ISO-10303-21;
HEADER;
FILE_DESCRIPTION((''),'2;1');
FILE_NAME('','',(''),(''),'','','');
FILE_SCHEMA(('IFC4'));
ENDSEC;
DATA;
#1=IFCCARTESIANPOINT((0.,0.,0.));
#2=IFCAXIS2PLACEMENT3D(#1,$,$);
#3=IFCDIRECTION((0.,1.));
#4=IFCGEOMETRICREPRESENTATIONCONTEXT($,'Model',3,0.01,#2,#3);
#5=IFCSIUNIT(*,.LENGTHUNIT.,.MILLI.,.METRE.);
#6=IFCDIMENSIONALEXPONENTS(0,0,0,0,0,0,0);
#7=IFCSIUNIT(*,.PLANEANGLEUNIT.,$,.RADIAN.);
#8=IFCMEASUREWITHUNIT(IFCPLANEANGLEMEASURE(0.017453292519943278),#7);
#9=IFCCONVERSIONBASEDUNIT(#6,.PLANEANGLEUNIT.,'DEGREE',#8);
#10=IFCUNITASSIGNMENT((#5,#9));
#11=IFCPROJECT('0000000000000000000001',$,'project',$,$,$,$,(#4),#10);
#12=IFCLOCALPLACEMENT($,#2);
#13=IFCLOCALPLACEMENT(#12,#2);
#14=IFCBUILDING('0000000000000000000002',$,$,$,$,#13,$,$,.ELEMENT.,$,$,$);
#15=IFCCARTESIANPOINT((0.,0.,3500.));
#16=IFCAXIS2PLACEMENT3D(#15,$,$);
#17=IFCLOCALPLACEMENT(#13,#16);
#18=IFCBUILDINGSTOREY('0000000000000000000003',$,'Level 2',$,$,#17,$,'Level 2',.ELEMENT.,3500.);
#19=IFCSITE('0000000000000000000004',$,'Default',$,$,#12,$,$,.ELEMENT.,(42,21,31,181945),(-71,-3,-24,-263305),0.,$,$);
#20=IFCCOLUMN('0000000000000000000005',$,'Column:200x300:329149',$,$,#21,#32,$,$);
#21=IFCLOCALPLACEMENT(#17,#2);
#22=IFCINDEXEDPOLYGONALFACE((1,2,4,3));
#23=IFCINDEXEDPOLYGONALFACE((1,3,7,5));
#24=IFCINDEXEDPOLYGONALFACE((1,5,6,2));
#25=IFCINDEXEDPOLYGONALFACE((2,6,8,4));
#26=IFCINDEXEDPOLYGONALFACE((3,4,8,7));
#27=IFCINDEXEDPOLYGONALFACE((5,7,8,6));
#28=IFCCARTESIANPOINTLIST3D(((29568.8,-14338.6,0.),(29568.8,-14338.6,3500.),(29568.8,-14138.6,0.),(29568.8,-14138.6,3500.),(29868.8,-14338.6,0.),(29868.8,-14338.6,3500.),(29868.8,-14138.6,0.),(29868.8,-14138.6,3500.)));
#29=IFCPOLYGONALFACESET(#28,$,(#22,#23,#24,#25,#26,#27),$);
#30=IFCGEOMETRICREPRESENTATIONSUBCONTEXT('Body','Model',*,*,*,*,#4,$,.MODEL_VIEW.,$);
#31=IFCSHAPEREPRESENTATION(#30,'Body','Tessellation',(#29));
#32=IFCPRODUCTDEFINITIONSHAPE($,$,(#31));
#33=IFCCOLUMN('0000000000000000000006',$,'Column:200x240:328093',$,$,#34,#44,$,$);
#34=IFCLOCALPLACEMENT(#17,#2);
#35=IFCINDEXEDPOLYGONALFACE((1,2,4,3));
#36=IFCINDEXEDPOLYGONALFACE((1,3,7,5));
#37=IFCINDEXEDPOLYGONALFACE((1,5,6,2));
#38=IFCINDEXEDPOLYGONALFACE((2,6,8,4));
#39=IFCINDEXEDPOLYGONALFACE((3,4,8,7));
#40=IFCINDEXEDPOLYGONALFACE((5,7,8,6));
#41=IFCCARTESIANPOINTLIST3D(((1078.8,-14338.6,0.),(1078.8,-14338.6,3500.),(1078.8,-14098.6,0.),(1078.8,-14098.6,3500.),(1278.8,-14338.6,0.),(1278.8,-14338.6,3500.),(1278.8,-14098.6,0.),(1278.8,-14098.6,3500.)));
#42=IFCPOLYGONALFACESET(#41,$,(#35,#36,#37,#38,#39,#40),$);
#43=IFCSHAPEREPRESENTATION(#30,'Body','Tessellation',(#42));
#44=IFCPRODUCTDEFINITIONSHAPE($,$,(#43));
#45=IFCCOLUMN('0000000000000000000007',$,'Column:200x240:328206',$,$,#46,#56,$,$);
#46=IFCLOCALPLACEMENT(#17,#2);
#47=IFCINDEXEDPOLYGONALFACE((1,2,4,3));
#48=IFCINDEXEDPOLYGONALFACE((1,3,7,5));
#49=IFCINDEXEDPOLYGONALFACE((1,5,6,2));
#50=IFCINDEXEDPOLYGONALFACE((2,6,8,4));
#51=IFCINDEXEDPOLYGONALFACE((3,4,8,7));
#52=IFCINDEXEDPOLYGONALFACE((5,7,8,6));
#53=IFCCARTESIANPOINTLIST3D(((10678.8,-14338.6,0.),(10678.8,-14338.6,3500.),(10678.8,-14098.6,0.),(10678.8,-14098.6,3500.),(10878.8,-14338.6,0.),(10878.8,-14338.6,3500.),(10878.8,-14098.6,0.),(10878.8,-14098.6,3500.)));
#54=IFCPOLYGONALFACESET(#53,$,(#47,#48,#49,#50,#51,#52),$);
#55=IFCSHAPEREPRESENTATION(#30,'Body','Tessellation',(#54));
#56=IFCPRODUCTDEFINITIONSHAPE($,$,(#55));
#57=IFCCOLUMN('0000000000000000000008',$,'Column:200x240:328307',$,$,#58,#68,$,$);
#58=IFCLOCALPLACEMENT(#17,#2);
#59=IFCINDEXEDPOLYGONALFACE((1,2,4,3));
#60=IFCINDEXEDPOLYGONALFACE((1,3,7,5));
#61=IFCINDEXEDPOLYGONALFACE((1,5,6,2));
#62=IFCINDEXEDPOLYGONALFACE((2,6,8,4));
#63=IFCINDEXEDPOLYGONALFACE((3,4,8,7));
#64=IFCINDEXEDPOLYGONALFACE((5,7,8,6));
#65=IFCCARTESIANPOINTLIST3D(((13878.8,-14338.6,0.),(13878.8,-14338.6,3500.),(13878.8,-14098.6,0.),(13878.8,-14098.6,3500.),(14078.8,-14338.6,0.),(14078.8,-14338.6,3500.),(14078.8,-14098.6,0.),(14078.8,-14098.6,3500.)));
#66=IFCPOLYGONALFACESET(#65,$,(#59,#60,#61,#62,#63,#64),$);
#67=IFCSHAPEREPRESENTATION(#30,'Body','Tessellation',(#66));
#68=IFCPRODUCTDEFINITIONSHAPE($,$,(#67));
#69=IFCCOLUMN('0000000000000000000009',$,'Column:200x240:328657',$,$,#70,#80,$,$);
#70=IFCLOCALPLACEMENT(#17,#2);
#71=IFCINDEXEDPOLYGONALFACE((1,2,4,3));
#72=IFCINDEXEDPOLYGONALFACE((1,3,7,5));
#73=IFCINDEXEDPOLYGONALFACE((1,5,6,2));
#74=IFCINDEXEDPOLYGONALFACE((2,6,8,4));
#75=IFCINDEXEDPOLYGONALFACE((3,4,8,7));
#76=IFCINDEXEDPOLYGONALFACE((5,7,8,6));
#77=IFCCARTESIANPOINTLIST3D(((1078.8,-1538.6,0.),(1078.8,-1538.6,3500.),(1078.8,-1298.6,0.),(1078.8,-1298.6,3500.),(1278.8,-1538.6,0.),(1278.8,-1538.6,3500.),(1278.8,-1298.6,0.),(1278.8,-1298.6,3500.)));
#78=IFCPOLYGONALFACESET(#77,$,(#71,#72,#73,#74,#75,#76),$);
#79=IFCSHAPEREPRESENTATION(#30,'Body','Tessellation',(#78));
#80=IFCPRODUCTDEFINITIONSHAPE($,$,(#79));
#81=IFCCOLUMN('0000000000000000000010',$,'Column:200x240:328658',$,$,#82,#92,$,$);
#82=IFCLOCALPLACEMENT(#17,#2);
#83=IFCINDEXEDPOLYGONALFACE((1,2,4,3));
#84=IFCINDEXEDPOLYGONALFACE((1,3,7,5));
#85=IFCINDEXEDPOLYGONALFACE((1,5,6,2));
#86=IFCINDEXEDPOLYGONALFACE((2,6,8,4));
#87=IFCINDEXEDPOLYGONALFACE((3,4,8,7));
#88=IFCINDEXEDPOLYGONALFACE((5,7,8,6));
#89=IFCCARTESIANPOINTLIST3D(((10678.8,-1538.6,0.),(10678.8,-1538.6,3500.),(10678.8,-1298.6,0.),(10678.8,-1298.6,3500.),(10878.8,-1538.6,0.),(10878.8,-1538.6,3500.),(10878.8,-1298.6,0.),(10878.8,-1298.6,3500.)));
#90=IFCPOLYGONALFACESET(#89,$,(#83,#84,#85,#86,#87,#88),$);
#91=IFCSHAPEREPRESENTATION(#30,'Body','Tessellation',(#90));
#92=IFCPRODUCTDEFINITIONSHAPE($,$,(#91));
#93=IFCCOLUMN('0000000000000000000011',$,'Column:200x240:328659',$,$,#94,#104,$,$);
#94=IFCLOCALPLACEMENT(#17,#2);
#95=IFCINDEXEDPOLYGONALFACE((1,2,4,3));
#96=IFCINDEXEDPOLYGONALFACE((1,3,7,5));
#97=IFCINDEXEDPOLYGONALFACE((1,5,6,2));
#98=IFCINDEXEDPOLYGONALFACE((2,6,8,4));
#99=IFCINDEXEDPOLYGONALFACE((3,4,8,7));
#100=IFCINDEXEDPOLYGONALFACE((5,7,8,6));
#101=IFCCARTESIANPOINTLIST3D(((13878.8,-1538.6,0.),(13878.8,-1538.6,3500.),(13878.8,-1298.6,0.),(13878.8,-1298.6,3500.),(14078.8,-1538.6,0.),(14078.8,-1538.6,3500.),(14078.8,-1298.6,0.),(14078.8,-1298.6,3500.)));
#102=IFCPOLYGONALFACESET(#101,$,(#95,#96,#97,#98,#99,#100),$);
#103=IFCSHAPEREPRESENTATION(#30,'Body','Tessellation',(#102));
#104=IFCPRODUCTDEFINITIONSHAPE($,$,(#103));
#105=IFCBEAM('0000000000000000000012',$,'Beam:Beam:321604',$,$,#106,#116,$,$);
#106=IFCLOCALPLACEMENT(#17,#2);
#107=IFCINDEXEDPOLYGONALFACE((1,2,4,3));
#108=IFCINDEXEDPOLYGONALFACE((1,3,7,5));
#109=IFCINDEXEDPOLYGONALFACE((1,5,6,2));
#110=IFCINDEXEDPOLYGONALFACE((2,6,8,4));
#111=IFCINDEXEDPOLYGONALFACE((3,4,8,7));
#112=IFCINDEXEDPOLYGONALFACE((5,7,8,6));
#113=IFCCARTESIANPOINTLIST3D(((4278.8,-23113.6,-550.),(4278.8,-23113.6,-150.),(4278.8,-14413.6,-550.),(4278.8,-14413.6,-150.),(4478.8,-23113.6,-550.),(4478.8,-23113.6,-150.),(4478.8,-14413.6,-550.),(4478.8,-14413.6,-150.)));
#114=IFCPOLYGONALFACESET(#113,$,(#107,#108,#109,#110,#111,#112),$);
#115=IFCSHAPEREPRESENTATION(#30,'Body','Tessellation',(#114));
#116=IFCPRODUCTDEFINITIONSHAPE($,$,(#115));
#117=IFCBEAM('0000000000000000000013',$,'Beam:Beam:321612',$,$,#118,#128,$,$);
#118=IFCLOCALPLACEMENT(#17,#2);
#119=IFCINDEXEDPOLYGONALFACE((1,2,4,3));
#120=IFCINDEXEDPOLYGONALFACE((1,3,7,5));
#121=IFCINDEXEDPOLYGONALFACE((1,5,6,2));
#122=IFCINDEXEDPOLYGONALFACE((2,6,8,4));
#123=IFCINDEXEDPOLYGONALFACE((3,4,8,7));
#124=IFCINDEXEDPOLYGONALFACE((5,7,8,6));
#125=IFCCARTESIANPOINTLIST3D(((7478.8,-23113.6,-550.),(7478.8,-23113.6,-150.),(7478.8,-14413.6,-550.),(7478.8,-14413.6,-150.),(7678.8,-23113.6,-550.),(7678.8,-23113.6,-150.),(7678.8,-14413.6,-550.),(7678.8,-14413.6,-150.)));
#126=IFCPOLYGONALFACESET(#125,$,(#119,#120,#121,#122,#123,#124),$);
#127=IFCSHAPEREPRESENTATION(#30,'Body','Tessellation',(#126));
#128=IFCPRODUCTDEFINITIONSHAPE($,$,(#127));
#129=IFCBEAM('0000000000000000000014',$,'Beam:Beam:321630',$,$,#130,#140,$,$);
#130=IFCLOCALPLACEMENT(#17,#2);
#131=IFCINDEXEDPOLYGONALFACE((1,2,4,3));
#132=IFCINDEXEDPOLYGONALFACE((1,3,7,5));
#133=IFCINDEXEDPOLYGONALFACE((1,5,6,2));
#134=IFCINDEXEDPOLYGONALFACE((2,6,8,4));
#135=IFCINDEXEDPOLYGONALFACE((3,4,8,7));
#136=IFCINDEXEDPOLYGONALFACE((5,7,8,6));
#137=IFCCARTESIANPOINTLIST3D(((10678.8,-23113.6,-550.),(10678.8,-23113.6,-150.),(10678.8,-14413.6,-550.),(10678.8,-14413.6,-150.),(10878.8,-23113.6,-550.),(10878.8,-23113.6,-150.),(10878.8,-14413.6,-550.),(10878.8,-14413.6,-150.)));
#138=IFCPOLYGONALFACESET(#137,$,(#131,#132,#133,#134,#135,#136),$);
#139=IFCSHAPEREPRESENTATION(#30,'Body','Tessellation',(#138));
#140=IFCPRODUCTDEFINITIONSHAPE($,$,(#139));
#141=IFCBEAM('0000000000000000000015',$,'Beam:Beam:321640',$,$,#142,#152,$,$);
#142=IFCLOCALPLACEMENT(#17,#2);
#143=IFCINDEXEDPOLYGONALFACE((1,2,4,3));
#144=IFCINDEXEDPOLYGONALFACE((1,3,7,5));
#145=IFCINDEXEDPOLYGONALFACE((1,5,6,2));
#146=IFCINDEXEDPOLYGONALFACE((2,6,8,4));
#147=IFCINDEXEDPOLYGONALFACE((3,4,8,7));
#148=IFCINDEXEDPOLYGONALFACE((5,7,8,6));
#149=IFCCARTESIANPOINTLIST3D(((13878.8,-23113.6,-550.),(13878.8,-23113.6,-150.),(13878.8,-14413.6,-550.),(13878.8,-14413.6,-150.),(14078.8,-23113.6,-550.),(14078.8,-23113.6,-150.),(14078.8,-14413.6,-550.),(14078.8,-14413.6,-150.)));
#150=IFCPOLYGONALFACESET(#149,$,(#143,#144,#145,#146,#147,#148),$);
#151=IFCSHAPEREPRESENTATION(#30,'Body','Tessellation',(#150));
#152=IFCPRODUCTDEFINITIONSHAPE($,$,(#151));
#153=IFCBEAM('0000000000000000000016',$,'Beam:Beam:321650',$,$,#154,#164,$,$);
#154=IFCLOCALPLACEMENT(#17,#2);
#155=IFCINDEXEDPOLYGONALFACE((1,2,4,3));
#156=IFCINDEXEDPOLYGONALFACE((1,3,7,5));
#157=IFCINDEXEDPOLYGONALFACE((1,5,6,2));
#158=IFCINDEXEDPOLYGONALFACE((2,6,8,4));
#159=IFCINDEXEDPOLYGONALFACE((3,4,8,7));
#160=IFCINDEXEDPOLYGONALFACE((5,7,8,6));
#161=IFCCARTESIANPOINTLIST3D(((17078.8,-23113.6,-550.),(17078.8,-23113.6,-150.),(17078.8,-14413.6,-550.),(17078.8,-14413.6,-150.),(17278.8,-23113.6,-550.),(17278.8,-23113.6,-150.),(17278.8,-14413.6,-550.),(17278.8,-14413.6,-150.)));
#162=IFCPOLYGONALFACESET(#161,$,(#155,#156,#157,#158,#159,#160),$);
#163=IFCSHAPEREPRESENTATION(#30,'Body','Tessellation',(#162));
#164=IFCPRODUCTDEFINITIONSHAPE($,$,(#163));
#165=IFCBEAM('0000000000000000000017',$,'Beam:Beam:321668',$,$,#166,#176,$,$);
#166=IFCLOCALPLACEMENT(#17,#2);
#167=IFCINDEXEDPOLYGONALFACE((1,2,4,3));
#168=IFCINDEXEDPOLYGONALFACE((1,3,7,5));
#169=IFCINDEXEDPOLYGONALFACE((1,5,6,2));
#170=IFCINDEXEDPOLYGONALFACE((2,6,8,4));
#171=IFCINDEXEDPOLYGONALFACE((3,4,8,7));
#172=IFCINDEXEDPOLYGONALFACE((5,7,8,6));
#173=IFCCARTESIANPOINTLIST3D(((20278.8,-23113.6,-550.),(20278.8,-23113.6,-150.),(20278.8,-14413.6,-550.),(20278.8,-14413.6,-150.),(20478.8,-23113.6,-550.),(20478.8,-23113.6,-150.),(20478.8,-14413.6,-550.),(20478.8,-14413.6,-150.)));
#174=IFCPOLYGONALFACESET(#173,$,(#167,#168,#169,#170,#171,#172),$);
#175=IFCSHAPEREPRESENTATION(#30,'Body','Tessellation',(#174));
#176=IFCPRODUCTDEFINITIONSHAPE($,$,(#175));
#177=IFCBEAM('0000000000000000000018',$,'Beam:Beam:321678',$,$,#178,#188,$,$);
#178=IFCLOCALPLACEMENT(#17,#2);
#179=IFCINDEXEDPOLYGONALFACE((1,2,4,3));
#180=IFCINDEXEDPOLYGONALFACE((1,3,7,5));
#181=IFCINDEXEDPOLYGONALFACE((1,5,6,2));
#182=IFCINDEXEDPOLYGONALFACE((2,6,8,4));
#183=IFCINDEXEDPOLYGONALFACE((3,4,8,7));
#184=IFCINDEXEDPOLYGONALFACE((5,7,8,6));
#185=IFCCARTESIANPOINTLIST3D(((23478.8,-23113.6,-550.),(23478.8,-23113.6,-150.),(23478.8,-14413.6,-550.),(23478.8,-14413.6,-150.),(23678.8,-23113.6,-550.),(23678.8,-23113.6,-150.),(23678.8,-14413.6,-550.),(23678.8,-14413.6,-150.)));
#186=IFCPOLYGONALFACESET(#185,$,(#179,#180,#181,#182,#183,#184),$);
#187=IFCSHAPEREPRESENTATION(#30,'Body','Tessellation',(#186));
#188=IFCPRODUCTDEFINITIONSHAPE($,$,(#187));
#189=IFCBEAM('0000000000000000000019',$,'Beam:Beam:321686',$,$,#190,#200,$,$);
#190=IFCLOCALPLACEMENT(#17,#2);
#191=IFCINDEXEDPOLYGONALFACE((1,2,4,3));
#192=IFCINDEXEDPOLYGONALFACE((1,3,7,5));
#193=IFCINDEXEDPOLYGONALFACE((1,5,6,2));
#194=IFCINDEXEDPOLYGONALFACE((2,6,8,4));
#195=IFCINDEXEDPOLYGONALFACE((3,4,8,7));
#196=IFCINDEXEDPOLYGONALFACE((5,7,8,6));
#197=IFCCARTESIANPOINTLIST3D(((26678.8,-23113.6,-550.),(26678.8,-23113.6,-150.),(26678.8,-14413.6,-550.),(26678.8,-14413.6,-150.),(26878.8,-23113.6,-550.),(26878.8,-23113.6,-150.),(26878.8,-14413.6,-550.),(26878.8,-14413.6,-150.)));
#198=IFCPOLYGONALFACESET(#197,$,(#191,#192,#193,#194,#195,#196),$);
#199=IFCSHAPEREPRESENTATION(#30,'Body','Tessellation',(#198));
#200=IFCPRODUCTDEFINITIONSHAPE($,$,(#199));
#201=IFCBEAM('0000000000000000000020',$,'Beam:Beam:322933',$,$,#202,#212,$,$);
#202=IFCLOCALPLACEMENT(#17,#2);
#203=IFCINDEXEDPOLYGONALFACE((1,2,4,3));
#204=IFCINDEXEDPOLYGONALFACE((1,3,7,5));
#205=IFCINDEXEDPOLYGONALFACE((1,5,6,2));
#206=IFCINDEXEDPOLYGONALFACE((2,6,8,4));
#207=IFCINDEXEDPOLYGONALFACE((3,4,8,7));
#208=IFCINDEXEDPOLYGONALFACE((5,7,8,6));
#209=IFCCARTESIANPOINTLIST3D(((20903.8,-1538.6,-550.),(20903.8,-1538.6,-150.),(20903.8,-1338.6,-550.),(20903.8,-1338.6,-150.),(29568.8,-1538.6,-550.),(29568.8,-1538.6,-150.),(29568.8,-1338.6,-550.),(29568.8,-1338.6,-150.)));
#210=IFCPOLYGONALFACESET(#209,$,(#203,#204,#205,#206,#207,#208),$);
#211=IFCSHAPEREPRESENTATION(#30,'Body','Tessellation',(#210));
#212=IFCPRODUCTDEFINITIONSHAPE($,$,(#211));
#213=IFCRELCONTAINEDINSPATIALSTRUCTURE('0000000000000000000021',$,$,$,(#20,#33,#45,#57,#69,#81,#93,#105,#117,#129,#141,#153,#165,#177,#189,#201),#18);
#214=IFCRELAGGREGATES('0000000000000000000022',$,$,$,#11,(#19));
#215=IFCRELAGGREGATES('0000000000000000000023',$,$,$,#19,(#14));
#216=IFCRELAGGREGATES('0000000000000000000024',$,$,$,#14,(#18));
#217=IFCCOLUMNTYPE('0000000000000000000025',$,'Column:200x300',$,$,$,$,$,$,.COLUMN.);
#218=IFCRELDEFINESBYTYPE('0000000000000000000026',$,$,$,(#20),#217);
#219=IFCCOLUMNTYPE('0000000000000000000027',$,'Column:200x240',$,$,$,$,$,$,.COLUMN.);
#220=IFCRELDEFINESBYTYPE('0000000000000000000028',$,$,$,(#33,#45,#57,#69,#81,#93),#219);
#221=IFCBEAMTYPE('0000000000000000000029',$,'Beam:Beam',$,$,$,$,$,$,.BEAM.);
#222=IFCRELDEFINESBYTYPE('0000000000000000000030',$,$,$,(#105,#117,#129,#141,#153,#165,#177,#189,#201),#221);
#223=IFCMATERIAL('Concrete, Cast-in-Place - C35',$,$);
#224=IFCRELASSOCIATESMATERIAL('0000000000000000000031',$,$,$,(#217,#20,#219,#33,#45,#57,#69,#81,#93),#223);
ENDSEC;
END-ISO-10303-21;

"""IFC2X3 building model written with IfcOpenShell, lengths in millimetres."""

from ifc_helpers import new_model, entity, si_unit, converted_unit, direction, frame, frame_2d, origin, origin_2d_with_axis, place, context, subcontext, project, spatial, rectangle, extrude, source, transform, mapped, material, type_object, type_shapes, element, save


model = new_model("IFC2X3")

# Units and contexts
model_context = context("Model", 3, precision=0.01, world=origin(), true_north=direction((0.0, 1.0)))
body_context = subcontext(model_context, "Body", "Model", "MODEL_VIEW")
ifc_project = project(units=[si_unit("LENGTHUNIT", "METRE", prefix="MILLI"), converted_unit("PLANEANGLEUNIT", "DEGREE", entity("IfcPlaneAngleMeasure", 0.017453292519943278), si_unit("PLANEANGLEUNIT", "RADIAN"), dimensions=[0, 0, 0, 0, 0, 0, 0])], contexts=[model_context])

# Site, building, storey
site_placement = place(None, origin())
site = spatial("IfcSite", under=ifc_project, at=site_placement, Name="Default", CompositionType="ELEMENT", RefLatitude=(42, 21, 31, 181945), RefLongitude=(-71, -3, -24, -263305), RefElevation=0.0)
building_placement = place(site_placement, origin())
building = spatial("IfcBuilding", under=site, at=building_placement, CompositionType="ELEMENT")
storey_placement = place(building_placement, frame((0.0, 0.0, 3500.0)))
storey = spatial("IfcBuildingStorey", under=building, at=storey_placement, Name="Level 2", LongName="Level 2", CompositionType="ELEMENT", Elevation=3500.0)

# Columns
ifc_material_1 = material(Name="Concrete, Cast-in-Place - C35")
column_type_1 = type_object("IfcColumnType", Name="Column:200x300", PredefinedType="COLUMN", material=ifc_material_1)
shared_shape_1 = source(origin(), body_context, "Body", "SweptSolid", [
    extrude(rectangle(XDim=300.0, YDim=200.0, at=origin_2d_with_axis()), frame((-50.0, 0.0, 3500.0), z_axis=(0.0, 0.0, 1.0), x_axis=(-1.0, 0.0, 0.0)), (0.0, 0.0, 1.0), 3500.0),
])
type_shapes(column_type_1, [shared_shape_1])
for number, where, name in (
    (1, (29768.8, -14238.6, -3500.0), "Column:200x300:329149"),
):
    element("IfcColumn", number, at=place(storey_placement, frame(where)), inside=storey, type_object=column_type_1, material=ifc_material_1, Name=name, context=body_context, shape_type="MappedRepresentation", body=[
        mapped(shared_shape_1, transform((0.0, 0.0, 0.0), scale=1.0)),
    ])
column_type_2 = type_object("IfcColumnType", Name="Column:200x240", PredefinedType="COLUMN", material=ifc_material_1)
shared_shape_2 = source(origin(), body_context, "Body", "SweptSolid", [
    extrude(rectangle(XDim=200.0, YDim=240.0, at=frame_2d((0.0, 0.0), x_axis=(1.0, 0.0))), frame((0.0, 20.0, 3500.0), z_axis=(0.0, 0.0, 1.0), x_axis=(-1.0, 0.0, 0.0)), (0.0, 0.0, 1.0), 3500.0),
])
type_shapes(column_type_2, [shared_shape_2])
for number, where, name in (
    (2, (1178.8, -14238.6, -3500.0), "Column:200x240:328093"),
    (3, (10778.8, -14238.6, -3500.0), "Column:200x240:328206"),
    (4, (13978.8, -14238.6, -3500.0), "Column:200x240:328307"),
    (5, (1178.8, -1438.6, -3500.0), "Column:200x240:328657"),
    (6, (10778.8, -1438.6, -3500.0), "Column:200x240:328658"),
    (7, (13978.8, -1438.6, -3500.0), "Column:200x240:328659"),
):
    element("IfcColumn", number, at=place(storey_placement, frame(where)), inside=storey, type_object=column_type_2, material=ifc_material_1, Name=name, context=body_context, shape_type="MappedRepresentation", body=[
        mapped(shared_shape_2, transform((0.0, 0.0, 0.0), scale=1.0)),
    ])

# Beams
beam_type = type_object("IfcBeamType", Name="Beam:Beam", PredefinedType="BEAM")
beam_1_placement = place(storey_placement, frame((4353.8, -14413.6, -150.0), z_axis=(0.0, 0.0, 1.0), x_axis=(0.0, -1.0, 0.0)))
element("IfcBeam", 8, at=beam_1_placement, inside=storey, type_object=beam_type, Name="Beam:Beam:321604", context=body_context, shape_type="SweptSolid", body=[
    extrude(rectangle(XDim=400.0, YDim=200.0, at=frame_2d((0.0, 0.0), x_axis=(1.0, 0.0))), frame((0.0, 25.0, -200.0), z_axis=(1.0, 0.0, 0.0), x_axis=(0.0, 0.0, -1.0)), (0.0, 0.0, 1.0), 8700.0),
])
beam_2_placement = place(storey_placement, frame((7553.8, -14413.6, -150.0), z_axis=(0.0, 0.0, 1.0), x_axis=(0.0, -1.0, 0.0)))
element("IfcBeam", 9, at=beam_2_placement, inside=storey, type_object=beam_type, Name="Beam:Beam:321612", context=body_context, shape_type="SweptSolid", body=[
    extrude(rectangle(XDim=400.0, YDim=200.0, at=frame_2d((0.0, 0.0), x_axis=(1.0, 0.0))), frame((0.0, 25.0, -200.0), z_axis=(1.0, 0.0, 0.0), x_axis=(0.0, 0.0, -1.0)), (0.0, 0.0, 1.0), 8700.0),
])
for number, where, z_axis, x_axis, name in (
    (10, (10753.8, -14413.6, -150.0), (0.0, 0.0, 1.0), (0.0, -1.0, 0.0), "Beam:Beam:321630"),
    (11, (13953.8, -14413.6, -150.0), (0.0, 0.0, 1.0), (0.0, -1.0, 0.0), "Beam:Beam:321640"),
    (12, (17153.8, -14413.6, -150.0), (0.0, 0.0, 1.0), (0.0, -1.0, 0.0), "Beam:Beam:321650"),
):
    element("IfcBeam", number, at=place(storey_placement, frame(where, z_axis=z_axis, x_axis=x_axis)), inside=storey, type_object=beam_type, Name=name, context=body_context, shape_type="SweptSolid", body=[
        extrude(rectangle(XDim=400.0, YDim=200.0, at=frame_2d((0.0, 0.0), x_axis=(1.0, 0.0))), frame((0.0, 25.0, -200.0), z_axis=(1.0, 0.0, 0.0), x_axis=(0.0, 0.0, -1.0)), (0.0, 0.0, 1.0), 8700.0),
    ])
for number, where, z_axis, x_axis, name in (
    (13, (20353.8, -14413.6, -150.0), (0.0, 0.0, 1.0), (0.0, -1.0, 0.0), "Beam:Beam:321668"),
    (14, (23553.8, -14413.6, -150.0), (0.0, 0.0, 1.0), (0.0, -1.0, 0.0), "Beam:Beam:321678"),
):
    element("IfcBeam", number, at=place(storey_placement, frame(where, z_axis=z_axis, x_axis=x_axis)), inside=storey, type_object=beam_type, Name=name, context=body_context, shape_type="SweptSolid", body=[
        extrude(rectangle(XDim=400.0, YDim=200.0, at=frame_2d((0.0, 0.0), x_axis=(1.0, 0.0))), frame((0.0, 25.0, -200.0), z_axis=(1.0, 0.0, 0.0), x_axis=(0.0, 0.0, -1.0)), (0.0, 0.0, 1.0), 8700.0),
    ])
beam_3_placement = place(storey_placement, frame((26753.8, -14413.6, -150.0), z_axis=(0.0, 0.0, 1.0), x_axis=(0.0, -1.0, 0.0)))
element("IfcBeam", 15, at=beam_3_placement, inside=storey, type_object=beam_type, Name="Beam:Beam:321686", context=body_context, shape_type="SweptSolid", body=[
    extrude(rectangle(XDim=400.0, YDim=200.0, at=frame_2d((0.0, 0.0), x_axis=(1.0, 0.0))), frame((0.0, 25.0, -200.0), z_axis=(1.0, 0.0, 0.0), x_axis=(0.0, 0.0, -1.0)), (0.0, 0.0, 1.0), 8700.0),
])
beam_4_placement = place(storey_placement, frame((29568.8, -1413.6, -150.0), z_axis=(0.0, 0.0, 1.0), x_axis=(-1.0, 0.0, 0.0)))
element("IfcBeam", 16, at=beam_4_placement, inside=storey, type_object=beam_type, Name="Beam:Beam:322933", context=body_context, shape_type="SweptSolid", body=[
    extrude(rectangle(XDim=400.0, YDim=200.0, at=frame_2d((0.0, 0.0), x_axis=(1.0, 0.0))), frame((0.0, 25.0, -200.0), z_axis=(1.0, 0.0, 0.0), x_axis=(0.0, 0.0, -1.0)), (0.0, 0.0, 1.0), 8665.0),
])

save(model, "model.ifc")
